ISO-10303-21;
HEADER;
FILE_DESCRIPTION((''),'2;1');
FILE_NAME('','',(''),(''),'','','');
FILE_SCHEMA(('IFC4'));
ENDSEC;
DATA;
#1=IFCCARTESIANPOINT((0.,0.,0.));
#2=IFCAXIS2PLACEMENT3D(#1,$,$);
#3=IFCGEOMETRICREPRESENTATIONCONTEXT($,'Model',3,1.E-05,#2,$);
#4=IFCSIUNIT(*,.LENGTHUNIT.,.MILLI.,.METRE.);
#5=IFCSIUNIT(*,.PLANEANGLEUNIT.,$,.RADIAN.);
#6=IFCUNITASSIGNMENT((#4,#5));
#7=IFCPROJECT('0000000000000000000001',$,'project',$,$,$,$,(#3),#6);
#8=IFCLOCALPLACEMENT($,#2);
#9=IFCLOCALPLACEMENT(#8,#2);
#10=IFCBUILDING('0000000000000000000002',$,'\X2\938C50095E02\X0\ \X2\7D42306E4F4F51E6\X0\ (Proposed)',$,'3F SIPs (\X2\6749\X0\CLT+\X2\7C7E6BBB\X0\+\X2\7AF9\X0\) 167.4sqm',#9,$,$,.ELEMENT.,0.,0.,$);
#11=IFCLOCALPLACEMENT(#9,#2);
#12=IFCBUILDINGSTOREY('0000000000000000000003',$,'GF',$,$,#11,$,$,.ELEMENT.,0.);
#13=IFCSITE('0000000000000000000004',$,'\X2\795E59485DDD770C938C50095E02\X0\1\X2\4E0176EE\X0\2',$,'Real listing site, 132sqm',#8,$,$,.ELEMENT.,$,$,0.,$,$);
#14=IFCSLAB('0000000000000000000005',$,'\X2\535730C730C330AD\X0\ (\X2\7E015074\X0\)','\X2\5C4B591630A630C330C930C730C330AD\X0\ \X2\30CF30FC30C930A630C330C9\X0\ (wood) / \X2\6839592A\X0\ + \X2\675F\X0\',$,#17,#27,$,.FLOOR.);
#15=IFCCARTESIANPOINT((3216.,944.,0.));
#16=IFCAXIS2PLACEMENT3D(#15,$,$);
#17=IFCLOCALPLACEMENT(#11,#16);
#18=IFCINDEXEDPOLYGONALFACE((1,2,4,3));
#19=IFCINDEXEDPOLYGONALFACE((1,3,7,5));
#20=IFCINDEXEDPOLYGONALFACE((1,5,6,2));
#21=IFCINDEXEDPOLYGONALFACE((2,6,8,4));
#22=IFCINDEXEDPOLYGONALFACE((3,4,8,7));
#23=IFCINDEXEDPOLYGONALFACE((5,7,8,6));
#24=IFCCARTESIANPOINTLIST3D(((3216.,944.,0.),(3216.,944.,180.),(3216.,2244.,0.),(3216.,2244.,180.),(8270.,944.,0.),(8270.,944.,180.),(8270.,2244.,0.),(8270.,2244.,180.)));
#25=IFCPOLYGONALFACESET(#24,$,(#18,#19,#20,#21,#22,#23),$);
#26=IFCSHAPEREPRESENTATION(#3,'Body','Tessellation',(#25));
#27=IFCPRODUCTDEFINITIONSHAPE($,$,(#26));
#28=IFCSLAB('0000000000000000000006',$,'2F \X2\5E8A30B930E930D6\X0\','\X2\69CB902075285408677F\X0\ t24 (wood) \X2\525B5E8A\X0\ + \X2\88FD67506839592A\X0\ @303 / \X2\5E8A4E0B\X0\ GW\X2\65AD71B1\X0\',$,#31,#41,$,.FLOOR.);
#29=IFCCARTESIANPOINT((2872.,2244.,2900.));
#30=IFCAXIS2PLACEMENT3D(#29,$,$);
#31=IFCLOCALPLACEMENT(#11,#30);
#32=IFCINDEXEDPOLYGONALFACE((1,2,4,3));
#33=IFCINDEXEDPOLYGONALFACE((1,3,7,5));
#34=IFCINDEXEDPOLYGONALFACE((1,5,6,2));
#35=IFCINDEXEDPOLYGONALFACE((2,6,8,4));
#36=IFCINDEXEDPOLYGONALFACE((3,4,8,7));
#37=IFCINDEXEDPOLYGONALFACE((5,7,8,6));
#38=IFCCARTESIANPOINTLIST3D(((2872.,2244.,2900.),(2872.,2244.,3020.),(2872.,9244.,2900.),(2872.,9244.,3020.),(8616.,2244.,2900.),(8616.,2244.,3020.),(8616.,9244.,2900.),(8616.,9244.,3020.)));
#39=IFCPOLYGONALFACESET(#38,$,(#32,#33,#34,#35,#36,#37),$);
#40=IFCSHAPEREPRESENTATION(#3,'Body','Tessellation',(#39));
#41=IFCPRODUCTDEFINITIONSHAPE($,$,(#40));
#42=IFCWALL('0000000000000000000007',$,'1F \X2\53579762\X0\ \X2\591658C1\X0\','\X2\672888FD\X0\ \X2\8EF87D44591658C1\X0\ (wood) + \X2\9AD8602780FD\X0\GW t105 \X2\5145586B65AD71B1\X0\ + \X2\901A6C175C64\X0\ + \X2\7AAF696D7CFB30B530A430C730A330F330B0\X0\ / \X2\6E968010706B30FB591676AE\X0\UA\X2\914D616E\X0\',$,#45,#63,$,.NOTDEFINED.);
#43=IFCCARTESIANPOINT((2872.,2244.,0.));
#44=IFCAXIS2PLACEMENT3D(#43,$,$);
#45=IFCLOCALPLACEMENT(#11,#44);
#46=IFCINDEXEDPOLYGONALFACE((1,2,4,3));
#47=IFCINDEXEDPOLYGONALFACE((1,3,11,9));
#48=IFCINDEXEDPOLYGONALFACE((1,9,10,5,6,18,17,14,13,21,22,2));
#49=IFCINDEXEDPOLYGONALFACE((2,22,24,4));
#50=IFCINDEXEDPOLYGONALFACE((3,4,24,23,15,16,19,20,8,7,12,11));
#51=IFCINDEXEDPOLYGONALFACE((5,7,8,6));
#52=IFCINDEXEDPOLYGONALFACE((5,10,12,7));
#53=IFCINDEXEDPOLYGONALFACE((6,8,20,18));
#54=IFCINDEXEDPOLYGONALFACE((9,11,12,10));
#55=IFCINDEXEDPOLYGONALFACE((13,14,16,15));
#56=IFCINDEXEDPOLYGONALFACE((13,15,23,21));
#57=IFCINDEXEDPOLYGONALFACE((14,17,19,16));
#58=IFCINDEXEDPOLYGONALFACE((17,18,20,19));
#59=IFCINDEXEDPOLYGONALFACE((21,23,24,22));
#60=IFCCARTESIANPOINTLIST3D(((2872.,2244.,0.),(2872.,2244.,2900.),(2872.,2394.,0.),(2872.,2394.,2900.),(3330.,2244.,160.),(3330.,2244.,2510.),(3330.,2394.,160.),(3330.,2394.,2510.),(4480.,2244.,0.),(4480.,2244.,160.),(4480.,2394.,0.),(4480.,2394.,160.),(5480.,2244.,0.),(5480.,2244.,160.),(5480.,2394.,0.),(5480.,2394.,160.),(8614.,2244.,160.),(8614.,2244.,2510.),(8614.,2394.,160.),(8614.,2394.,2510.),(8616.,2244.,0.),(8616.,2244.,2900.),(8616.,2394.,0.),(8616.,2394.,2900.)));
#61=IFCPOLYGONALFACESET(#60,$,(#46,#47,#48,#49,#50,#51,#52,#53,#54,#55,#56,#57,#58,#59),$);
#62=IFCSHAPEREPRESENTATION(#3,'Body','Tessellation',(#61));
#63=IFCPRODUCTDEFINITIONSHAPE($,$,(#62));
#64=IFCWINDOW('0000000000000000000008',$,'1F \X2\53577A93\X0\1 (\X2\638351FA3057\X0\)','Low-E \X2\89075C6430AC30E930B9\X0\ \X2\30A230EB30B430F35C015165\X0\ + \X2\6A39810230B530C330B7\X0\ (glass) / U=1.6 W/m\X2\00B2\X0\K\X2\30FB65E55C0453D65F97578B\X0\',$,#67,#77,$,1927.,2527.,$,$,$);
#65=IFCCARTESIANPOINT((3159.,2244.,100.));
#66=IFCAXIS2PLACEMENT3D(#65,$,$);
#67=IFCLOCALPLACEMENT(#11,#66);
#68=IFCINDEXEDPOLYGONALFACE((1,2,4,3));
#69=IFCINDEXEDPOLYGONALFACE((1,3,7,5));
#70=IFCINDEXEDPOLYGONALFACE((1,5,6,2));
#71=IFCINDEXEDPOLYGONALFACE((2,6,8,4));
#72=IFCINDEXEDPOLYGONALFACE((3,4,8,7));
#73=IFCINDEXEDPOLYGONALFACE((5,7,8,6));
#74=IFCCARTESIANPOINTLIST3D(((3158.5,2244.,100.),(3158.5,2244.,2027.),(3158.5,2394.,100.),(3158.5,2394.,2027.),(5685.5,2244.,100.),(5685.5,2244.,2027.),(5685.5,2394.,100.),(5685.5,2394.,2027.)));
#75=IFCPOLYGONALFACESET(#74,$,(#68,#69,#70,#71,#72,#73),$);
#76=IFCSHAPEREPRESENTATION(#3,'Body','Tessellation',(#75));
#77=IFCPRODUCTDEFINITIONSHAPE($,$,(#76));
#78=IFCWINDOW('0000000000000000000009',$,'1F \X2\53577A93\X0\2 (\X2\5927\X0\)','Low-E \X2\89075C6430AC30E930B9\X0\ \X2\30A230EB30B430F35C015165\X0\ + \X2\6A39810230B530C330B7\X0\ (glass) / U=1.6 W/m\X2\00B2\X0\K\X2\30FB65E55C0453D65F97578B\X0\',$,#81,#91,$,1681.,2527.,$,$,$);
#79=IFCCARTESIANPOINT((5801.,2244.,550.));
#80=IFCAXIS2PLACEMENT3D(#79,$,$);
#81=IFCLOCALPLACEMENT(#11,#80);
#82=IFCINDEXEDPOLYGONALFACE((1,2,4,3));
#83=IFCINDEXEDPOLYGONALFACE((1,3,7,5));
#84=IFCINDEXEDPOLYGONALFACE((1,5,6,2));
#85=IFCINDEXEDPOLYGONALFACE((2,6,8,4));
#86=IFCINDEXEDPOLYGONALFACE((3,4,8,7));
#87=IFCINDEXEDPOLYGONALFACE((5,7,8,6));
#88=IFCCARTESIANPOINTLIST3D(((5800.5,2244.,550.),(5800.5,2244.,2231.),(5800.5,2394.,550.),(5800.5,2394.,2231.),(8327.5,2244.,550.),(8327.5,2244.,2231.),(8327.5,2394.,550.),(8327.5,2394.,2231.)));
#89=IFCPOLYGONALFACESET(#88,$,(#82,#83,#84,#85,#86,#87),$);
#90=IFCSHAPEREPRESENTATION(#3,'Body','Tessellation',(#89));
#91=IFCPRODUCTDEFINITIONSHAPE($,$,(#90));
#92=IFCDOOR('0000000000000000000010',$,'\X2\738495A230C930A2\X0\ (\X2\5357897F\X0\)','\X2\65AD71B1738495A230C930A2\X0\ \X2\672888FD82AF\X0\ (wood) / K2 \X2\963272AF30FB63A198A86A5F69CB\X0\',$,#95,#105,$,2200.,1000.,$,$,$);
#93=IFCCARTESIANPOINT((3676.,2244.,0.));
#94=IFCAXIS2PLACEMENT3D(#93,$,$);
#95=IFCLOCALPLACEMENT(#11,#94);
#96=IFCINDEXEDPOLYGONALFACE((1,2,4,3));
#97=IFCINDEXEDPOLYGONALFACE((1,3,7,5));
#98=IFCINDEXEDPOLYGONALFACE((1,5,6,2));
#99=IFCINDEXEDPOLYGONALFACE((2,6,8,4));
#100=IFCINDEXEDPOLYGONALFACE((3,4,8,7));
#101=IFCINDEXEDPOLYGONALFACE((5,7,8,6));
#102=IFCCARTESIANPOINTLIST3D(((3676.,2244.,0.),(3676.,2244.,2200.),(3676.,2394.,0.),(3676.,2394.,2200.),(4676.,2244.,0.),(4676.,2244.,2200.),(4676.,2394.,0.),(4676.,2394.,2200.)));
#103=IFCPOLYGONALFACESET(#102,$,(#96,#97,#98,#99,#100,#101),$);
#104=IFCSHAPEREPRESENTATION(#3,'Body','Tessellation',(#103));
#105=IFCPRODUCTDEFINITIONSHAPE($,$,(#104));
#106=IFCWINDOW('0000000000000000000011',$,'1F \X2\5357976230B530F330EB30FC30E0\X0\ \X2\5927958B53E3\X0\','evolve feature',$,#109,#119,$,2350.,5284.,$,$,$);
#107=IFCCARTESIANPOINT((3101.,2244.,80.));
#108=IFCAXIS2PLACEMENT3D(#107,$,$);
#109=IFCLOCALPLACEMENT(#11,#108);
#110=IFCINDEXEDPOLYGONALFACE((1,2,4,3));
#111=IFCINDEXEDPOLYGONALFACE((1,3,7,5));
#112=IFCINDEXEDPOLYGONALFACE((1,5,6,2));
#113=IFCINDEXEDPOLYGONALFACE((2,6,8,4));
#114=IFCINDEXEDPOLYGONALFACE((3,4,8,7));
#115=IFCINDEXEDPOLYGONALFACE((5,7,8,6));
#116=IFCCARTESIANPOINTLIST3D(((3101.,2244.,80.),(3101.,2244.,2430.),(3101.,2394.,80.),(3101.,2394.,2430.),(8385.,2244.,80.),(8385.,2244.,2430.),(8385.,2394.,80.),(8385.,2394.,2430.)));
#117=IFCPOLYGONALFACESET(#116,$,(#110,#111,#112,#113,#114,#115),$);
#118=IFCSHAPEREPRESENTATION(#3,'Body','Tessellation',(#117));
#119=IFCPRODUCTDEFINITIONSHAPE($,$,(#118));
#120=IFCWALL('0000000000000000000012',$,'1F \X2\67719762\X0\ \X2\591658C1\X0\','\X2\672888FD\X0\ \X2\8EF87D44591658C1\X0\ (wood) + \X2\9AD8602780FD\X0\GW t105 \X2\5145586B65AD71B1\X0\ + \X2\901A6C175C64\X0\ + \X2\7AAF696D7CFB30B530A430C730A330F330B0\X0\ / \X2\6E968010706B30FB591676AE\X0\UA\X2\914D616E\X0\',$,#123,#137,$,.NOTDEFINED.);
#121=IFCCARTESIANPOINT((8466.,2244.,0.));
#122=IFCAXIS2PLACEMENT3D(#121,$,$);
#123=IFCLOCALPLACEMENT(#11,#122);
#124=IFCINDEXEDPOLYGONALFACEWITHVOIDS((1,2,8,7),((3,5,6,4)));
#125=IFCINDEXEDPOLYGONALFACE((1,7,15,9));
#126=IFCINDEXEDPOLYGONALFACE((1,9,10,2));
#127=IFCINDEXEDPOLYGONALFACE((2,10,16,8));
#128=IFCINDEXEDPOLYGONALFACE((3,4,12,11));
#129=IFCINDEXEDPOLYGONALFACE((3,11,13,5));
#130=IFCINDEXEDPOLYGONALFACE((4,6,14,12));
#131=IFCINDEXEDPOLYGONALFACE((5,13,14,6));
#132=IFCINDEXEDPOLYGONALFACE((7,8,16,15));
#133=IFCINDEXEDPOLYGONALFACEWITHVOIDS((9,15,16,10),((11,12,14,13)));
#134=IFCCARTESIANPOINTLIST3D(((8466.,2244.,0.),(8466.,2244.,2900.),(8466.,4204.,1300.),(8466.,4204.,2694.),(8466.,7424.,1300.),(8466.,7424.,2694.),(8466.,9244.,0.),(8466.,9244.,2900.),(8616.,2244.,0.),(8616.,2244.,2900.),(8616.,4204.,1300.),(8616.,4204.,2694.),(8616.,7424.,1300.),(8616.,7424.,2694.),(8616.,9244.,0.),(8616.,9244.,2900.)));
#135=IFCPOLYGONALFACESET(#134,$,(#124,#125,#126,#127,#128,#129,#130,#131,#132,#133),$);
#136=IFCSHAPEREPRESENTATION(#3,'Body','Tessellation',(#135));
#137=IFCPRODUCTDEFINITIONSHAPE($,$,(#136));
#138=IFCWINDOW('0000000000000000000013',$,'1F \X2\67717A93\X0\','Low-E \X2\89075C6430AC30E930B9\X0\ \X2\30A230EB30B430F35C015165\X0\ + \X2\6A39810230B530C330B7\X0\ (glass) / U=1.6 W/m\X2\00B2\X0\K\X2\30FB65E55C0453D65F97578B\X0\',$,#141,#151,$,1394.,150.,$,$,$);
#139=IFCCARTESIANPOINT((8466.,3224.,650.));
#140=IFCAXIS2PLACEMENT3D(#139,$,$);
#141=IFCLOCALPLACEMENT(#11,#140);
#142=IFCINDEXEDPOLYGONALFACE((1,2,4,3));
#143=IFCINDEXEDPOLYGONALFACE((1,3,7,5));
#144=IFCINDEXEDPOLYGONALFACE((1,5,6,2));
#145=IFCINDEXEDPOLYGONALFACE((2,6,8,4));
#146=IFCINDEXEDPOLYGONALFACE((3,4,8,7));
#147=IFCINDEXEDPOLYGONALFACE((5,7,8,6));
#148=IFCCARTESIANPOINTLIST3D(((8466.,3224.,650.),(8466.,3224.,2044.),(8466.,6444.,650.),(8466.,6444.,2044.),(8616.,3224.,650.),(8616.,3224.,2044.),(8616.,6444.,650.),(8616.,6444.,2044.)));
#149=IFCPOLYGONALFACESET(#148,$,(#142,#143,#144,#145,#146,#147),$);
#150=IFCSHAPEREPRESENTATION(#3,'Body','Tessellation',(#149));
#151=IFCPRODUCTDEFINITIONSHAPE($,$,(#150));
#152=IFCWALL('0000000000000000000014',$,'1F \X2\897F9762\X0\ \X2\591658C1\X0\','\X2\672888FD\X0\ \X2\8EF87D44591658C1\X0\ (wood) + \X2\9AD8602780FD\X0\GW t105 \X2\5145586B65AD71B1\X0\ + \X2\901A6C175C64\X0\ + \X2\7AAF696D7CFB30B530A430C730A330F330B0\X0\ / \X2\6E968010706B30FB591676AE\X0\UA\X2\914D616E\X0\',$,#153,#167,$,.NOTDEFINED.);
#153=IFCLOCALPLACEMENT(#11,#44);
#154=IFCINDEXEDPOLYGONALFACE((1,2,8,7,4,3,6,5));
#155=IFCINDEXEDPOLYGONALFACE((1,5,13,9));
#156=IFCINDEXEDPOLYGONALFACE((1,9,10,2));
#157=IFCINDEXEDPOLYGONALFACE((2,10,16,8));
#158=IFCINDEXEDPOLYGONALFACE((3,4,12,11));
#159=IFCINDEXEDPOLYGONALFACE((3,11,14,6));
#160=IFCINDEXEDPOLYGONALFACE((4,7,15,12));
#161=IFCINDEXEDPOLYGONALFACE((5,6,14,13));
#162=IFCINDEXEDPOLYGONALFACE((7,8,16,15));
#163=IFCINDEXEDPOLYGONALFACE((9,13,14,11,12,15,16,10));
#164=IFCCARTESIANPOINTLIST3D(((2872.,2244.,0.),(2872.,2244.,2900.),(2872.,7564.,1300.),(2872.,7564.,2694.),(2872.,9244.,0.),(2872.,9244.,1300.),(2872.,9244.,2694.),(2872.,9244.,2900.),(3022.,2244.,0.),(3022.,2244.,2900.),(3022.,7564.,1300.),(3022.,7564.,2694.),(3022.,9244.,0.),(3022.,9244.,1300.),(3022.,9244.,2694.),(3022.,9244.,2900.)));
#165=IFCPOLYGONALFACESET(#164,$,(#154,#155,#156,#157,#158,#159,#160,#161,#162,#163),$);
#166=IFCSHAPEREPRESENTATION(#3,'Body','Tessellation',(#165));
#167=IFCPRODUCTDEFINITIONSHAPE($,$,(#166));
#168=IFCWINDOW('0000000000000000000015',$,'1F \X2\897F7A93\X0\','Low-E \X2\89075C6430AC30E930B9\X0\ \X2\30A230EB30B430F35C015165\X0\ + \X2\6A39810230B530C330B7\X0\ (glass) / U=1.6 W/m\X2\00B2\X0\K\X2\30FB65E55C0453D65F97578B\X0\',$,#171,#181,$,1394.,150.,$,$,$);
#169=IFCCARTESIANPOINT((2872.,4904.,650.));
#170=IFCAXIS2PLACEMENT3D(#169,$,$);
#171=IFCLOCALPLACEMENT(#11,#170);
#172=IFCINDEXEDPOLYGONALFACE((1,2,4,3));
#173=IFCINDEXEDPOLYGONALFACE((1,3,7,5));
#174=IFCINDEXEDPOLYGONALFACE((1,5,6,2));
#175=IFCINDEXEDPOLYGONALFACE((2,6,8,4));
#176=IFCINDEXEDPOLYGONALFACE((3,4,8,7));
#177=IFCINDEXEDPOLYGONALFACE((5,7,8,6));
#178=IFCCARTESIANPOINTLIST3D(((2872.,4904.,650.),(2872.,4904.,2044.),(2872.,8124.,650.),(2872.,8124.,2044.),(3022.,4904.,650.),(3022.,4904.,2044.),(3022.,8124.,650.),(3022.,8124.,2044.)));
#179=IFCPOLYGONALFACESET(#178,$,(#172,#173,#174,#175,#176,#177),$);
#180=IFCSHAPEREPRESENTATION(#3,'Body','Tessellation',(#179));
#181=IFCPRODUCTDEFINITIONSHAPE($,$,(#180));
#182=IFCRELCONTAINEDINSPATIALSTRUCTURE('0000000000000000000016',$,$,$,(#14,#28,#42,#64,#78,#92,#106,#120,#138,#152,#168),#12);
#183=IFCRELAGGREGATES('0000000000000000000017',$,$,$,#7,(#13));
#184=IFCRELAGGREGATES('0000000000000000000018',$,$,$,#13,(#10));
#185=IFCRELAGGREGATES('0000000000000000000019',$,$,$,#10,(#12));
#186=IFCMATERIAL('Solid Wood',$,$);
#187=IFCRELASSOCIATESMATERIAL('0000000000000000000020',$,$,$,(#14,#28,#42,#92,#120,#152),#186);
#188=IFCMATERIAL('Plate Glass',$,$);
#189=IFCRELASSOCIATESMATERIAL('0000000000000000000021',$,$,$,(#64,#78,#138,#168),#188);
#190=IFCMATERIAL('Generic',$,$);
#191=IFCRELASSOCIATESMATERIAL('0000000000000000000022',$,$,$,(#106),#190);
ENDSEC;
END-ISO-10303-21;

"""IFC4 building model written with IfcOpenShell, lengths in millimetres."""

from ifc_helpers import new_model, si_unit, frame, frame_2d, origin, place, context, project, spatial, rectangle, extrude, material, element, fill, save


model = new_model("IFC4")

# Units and contexts
model_context = context("Model", 3, precision=1e-05, world=origin())
ifc_project = project(units=[si_unit("LENGTHUNIT", "METRE", prefix="MILLI"), si_unit("PLANEANGLEUNIT", "RADIAN")], contexts=[model_context])

# Site, building, storey
site_placement = place(None, origin())
site = spatial("IfcSite", under=ifc_project, at=site_placement, Name="神奈川県鎌倉市1丁目2", ObjectType="Real listing site, 132sqm", CompositionType="ELEMENT", RefElevation=0.0)
building_placement = place(site_placement, origin())
building = spatial("IfcBuilding", under=site, at=building_placement, Name="鎌倉市 終の住処 (Proposed)", ObjectType="3F SIPs (杉CLT+籾殻+竹) 167.4sqm", CompositionType="ELEMENT", ElevationOfRefHeight=0.0, ElevationOfTerrain=0.0)
storey_placement = place(building_placement, origin())
storey = spatial("IfcBuildingStorey", under=building, at=storey_placement, Name="GF", CompositionType="ELEMENT", Elevation=0.0)

# Slabs
ifc_material_1 = material(Name="Solid Wood")
slab_1_placement = place(storey_placement, frame((3216.0, 944.0, 0.0)))
element("IfcSlab", 1, at=slab_1_placement, inside=storey, material=ifc_material_1, Name="南デッキ (縁側)", Description="屋外ウッドデッキ ハードウッド (wood) / 根太 + 束", PredefinedType="FLOOR", context=model_context, shape_type="SweptSolid", body=[
    extrude(rectangle(XDim=5054.0, YDim=1300.0, at=frame_2d((2527.0, 650.0))), frame((3216.0, 944.0, 0.0)), (0.0, 0.0, 1.0), 180.0),
])
slab_2_placement = place(storey_placement, frame((2872.0, 2244.0, 2900.0)))
element("IfcSlab", 2, at=slab_2_placement, inside=storey, material=ifc_material_1, Name="2F 床スラブ", Description="構造用合板 t24 (wood) 剛床 + 製材根太 @303 / 床下 GW断熱", PredefinedType="FLOOR", context=model_context, shape_type="SweptSolid", body=[
    extrude(rectangle(XDim=5744.0, YDim=7000.0, at=frame_2d((2872.0, 3500.0))), frame((2872.0, 2244.0, 2900.0)), (0.0, 0.0, 1.0), 120.0),
])

# Wall, openings, windows, door
wall_1_placement = place(storey_placement, frame((2872.0, 2244.0, 0.0)))
wall_1 = element("IfcWall", 3, at=wall_1_placement, inside=storey, material=ifc_material_1, Name="1F 南面 外壁", Description="木製 軸組外壁 (wood) + 高性能GW t105 充填断熱 + 通気層 + 窯業系サイディング / 準耐火・外皮UA配慮", PredefinedType="NOTDEFINED", context=model_context, shape_type="SweptSolid", body=[
    extrude(rectangle(XDim=5744.0, YDim=150.0, at=frame_2d((2872.0, 75.0))), frame((2872.0, 2244.0, 0.0)), (0.0, 0.0, 1.0), 2900.0),
])
opening_1_placement = place(storey_placement, frame((3159.0, 2244.0, 100.0)))
opening_1 = element("IfcOpeningElement", 4, at=opening_1_placement, cuts=wall_1, PredefinedType="NOTDEFINED", context=model_context, shape_type="SweptSolid", body=[
    extrude(rectangle(XDim=2527.0, YDim=150.0, at=frame_2d((1263.0, 75.0))), frame((3159.0, 2244.0, 100.0)), (0.0, 0.0, 1.0), 1927.0),
])
opening_2_placement = place(storey_placement, frame((5801.0, 2244.0, 550.0)))
opening_2 = element("IfcOpeningElement", 5, at=opening_2_placement, cuts=wall_1, PredefinedType="NOTDEFINED", context=model_context, shape_type="SweptSolid", body=[
    extrude(rectangle(XDim=2527.0, YDim=150.0, at=frame_2d((1263.0, 75.0))), frame((5801.0, 2244.0, 550.0)), (0.0, 0.0, 1.0), 1681.0),
])
opening_3_placement = place(storey_placement, frame((3676.0, 2244.0, 0.0)))
opening_3 = element("IfcOpeningElement", 6, at=opening_3_placement, cuts=wall_1, PredefinedType="NOTDEFINED", context=model_context, shape_type="SweptSolid", body=[
    extrude(rectangle(XDim=1000.0, YDim=150.0, at=frame_2d((500.0, 75.0))), frame((3676.0, 2244.0, 0.0)), (0.0, 0.0, 1.0), 2200.0),
])
opening_4_placement = place(storey_placement, frame((3101.0, 2244.0, 80.0)))
opening_4 = element("IfcOpeningElement", 7, at=opening_4_placement, cuts=wall_1, PredefinedType="NOTDEFINED", context=model_context, shape_type="SweptSolid", body=[
    extrude(rectangle(XDim=5284.0, YDim=150.0, at=frame_2d((2642.0, 75.0))), frame((3101.0, 2244.0, 80.0)), (0.0, 0.0, 1.0), 2350.0),
])
ifc_material_2 = material(Name="Plate Glass")
window_1_placement = place(storey_placement, frame((3159.0, 2244.0, 100.0)))
window_1 = element("IfcWindow", 8, at=window_1_placement, inside=storey, material=ifc_material_2, Name="1F 南窓1 (掃出し)", Description="Low-E 複層ガラス アルゴン封入 + 樹脂サッシ (glass) / U=1.6 W/m²K・日射取得型", OverallHeight=1927.0, OverallWidth=2527.0, context=model_context, shape_type="SweptSolid", body=[
    extrude(rectangle(XDim=2527.0, YDim=150.0, at=frame_2d((1263.0, 75.0))), frame((3159.0, 2244.0, 100.0)), (0.0, 0.0, 1.0), 1927.0),
])
fill(opening_1, window_1)
window_2_placement = place(storey_placement, frame((5801.0, 2244.0, 550.0)))
window_2 = element("IfcWindow", 9, at=window_2_placement, inside=storey, material=ifc_material_2, Name="1F 南窓2 (大)", Description="Low-E 複層ガラス アルゴン封入 + 樹脂サッシ (glass) / U=1.6 W/m²K・日射取得型", OverallHeight=1681.0, OverallWidth=2527.0, context=model_context, shape_type="SweptSolid", body=[
    extrude(rectangle(XDim=2527.0, YDim=150.0, at=frame_2d((1263.0, 75.0))), frame((5801.0, 2244.0, 550.0)), (0.0, 0.0, 1.0), 1681.0),
])
fill(opening_2, window_2)
door_placement = place(storey_placement, frame((3676.0, 2244.0, 0.0)))
door = element("IfcDoor", 10, at=door_placement, inside=storey, material=ifc_material_1, Name="玄関ドア (南西)", Description="断熱玄関ドア 木製芯 (wood) / K2 防犯・採風機構", OverallHeight=2200.0, OverallWidth=1000.0, context=model_context, shape_type="SweptSolid", body=[
    extrude(rectangle(XDim=1000.0, YDim=150.0, at=frame_2d((500.0, 75.0))), frame((3676.0, 2244.0, 0.0)), (0.0, 0.0, 1.0), 2200.0),
])
fill(opening_3, door)
ifc_material_3 = material(Name="Generic")
window_3_placement = place(storey_placement, frame((3101.0, 2244.0, 80.0)))
window_3 = element("IfcWindow", 11, at=window_3_placement, inside=storey, material=ifc_material_3, Name="1F 南面サンルーム 大開口", Description="evolve feature", OverallHeight=2350.0, OverallWidth=5284.0, context=model_context, shape_type="SweptSolid", body=[
    extrude(rectangle(XDim=5284.0, YDim=150.0, at=frame_2d((2642.0, 75.0))), frame((3101.0, 2244.0, 80.0)), (0.0, 0.0, 1.0), 2350.0),
])
fill(opening_4, window_3)

# Walls, openings, windows
wall_2_placement = place(storey_placement, frame((8466.0, 2244.0, 0.0)))
wall_2 = element("IfcWall", 12, at=wall_2_placement, inside=storey, material=ifc_material_1, Name="1F 東面 外壁", Description="木製 軸組外壁 (wood) + 高性能GW t105 充填断熱 + 通気層 + 窯業系サイディング / 準耐火・外皮UA配慮", PredefinedType="NOTDEFINED", context=model_context, shape_type="SweptSolid", body=[
    extrude(rectangle(XDim=150.0, YDim=7000.0, at=frame_2d((75.0, 3500.0))), frame((8466.0, 2244.0, 0.0)), (0.0, 0.0, 1.0), 2900.0),
])
opening_5_placement = place(storey_placement, frame((8466.0, 3224.0, 650.0)))
opening_5 = element("IfcOpeningElement", 13, at=opening_5_placement, cuts=wall_2, PredefinedType="NOTDEFINED", context=model_context, shape_type="SweptSolid", body=[
    extrude(rectangle(XDim=150.0, YDim=3220.0, at=frame_2d((75.0, 1610.0))), frame((8466.0, 3224.0, 650.0)), (0.0, 0.0, 1.0), 1394.0),
])
window_4_placement = place(storey_placement, frame((8466.0, 3224.0, 650.0)))
window_4 = element("IfcWindow", 14, at=window_4_placement, inside=storey, material=ifc_material_2, Name="1F 東窓", Description="Low-E 複層ガラス アルゴン封入 + 樹脂サッシ (glass) / U=1.6 W/m²K・日射取得型", OverallHeight=1394.0, OverallWidth=150.0, context=model_context, shape_type="SweptSolid", body=[
    extrude(rectangle(XDim=150.0, YDim=3220.0, at=frame_2d((75.0, 1610.0))), frame((8466.0, 3224.0, 650.0)), (0.0, 0.0, 1.0), 1394.0),
])
fill(opening_5, window_4)
wall_3_placement = place(storey_placement, frame((2872.0, 2244.0, 0.0)))
wall_3 = element("IfcWall", 15, at=wall_3_placement, inside=storey, material=ifc_material_1, Name="1F 西面 外壁", Description="木製 軸組外壁 (wood) + 高性能GW t105 充填断熱 + 通気層 + 窯業系サイディング / 準耐火・外皮UA配慮", PredefinedType="NOTDEFINED", context=model_context, shape_type="SweptSolid", body=[
    extrude(rectangle(XDim=150.0, YDim=7000.0, at=frame_2d((75.0, 3500.0))), frame((2872.0, 2244.0, 0.0)), (0.0, 0.0, 1.0), 2900.0),
])
opening_6_placement = place(storey_placement, frame((2872.0, 4904.0, 650.0)))
opening_6 = element("IfcOpeningElement", 16, at=opening_6_placement, cuts=wall_3, PredefinedType="NOTDEFINED", context=model_context, shape_type="SweptSolid", body=[
    extrude(rectangle(XDim=150.0, YDim=3220.0, at=frame_2d((75.0, 1610.0))), frame((2872.0, 4904.0, 650.0)), (0.0, 0.0, 1.0), 1394.0),
])
window_5_placement = place(storey_placement, frame((2872.0, 4904.0, 650.0)))
window_5 = element("IfcWindow", 17, at=window_5_placement, inside=storey, material=ifc_material_2, Name="1F 西窓", Description="Low-E 複層ガラス アルゴン封入 + 樹脂サッシ (glass) / U=1.6 W/m²K・日射取得型", OverallHeight=1394.0, OverallWidth=150.0, context=model_context, shape_type="SweptSolid", body=[
    extrude(rectangle(XDim=150.0, YDim=3220.0, at=frame_2d((75.0, 1610.0))), frame((2872.0, 4904.0, 650.0)), (0.0, 0.0, 1.0), 1394.0),
])
fill(opening_6, window_5)

save(model, "model.ifc")
